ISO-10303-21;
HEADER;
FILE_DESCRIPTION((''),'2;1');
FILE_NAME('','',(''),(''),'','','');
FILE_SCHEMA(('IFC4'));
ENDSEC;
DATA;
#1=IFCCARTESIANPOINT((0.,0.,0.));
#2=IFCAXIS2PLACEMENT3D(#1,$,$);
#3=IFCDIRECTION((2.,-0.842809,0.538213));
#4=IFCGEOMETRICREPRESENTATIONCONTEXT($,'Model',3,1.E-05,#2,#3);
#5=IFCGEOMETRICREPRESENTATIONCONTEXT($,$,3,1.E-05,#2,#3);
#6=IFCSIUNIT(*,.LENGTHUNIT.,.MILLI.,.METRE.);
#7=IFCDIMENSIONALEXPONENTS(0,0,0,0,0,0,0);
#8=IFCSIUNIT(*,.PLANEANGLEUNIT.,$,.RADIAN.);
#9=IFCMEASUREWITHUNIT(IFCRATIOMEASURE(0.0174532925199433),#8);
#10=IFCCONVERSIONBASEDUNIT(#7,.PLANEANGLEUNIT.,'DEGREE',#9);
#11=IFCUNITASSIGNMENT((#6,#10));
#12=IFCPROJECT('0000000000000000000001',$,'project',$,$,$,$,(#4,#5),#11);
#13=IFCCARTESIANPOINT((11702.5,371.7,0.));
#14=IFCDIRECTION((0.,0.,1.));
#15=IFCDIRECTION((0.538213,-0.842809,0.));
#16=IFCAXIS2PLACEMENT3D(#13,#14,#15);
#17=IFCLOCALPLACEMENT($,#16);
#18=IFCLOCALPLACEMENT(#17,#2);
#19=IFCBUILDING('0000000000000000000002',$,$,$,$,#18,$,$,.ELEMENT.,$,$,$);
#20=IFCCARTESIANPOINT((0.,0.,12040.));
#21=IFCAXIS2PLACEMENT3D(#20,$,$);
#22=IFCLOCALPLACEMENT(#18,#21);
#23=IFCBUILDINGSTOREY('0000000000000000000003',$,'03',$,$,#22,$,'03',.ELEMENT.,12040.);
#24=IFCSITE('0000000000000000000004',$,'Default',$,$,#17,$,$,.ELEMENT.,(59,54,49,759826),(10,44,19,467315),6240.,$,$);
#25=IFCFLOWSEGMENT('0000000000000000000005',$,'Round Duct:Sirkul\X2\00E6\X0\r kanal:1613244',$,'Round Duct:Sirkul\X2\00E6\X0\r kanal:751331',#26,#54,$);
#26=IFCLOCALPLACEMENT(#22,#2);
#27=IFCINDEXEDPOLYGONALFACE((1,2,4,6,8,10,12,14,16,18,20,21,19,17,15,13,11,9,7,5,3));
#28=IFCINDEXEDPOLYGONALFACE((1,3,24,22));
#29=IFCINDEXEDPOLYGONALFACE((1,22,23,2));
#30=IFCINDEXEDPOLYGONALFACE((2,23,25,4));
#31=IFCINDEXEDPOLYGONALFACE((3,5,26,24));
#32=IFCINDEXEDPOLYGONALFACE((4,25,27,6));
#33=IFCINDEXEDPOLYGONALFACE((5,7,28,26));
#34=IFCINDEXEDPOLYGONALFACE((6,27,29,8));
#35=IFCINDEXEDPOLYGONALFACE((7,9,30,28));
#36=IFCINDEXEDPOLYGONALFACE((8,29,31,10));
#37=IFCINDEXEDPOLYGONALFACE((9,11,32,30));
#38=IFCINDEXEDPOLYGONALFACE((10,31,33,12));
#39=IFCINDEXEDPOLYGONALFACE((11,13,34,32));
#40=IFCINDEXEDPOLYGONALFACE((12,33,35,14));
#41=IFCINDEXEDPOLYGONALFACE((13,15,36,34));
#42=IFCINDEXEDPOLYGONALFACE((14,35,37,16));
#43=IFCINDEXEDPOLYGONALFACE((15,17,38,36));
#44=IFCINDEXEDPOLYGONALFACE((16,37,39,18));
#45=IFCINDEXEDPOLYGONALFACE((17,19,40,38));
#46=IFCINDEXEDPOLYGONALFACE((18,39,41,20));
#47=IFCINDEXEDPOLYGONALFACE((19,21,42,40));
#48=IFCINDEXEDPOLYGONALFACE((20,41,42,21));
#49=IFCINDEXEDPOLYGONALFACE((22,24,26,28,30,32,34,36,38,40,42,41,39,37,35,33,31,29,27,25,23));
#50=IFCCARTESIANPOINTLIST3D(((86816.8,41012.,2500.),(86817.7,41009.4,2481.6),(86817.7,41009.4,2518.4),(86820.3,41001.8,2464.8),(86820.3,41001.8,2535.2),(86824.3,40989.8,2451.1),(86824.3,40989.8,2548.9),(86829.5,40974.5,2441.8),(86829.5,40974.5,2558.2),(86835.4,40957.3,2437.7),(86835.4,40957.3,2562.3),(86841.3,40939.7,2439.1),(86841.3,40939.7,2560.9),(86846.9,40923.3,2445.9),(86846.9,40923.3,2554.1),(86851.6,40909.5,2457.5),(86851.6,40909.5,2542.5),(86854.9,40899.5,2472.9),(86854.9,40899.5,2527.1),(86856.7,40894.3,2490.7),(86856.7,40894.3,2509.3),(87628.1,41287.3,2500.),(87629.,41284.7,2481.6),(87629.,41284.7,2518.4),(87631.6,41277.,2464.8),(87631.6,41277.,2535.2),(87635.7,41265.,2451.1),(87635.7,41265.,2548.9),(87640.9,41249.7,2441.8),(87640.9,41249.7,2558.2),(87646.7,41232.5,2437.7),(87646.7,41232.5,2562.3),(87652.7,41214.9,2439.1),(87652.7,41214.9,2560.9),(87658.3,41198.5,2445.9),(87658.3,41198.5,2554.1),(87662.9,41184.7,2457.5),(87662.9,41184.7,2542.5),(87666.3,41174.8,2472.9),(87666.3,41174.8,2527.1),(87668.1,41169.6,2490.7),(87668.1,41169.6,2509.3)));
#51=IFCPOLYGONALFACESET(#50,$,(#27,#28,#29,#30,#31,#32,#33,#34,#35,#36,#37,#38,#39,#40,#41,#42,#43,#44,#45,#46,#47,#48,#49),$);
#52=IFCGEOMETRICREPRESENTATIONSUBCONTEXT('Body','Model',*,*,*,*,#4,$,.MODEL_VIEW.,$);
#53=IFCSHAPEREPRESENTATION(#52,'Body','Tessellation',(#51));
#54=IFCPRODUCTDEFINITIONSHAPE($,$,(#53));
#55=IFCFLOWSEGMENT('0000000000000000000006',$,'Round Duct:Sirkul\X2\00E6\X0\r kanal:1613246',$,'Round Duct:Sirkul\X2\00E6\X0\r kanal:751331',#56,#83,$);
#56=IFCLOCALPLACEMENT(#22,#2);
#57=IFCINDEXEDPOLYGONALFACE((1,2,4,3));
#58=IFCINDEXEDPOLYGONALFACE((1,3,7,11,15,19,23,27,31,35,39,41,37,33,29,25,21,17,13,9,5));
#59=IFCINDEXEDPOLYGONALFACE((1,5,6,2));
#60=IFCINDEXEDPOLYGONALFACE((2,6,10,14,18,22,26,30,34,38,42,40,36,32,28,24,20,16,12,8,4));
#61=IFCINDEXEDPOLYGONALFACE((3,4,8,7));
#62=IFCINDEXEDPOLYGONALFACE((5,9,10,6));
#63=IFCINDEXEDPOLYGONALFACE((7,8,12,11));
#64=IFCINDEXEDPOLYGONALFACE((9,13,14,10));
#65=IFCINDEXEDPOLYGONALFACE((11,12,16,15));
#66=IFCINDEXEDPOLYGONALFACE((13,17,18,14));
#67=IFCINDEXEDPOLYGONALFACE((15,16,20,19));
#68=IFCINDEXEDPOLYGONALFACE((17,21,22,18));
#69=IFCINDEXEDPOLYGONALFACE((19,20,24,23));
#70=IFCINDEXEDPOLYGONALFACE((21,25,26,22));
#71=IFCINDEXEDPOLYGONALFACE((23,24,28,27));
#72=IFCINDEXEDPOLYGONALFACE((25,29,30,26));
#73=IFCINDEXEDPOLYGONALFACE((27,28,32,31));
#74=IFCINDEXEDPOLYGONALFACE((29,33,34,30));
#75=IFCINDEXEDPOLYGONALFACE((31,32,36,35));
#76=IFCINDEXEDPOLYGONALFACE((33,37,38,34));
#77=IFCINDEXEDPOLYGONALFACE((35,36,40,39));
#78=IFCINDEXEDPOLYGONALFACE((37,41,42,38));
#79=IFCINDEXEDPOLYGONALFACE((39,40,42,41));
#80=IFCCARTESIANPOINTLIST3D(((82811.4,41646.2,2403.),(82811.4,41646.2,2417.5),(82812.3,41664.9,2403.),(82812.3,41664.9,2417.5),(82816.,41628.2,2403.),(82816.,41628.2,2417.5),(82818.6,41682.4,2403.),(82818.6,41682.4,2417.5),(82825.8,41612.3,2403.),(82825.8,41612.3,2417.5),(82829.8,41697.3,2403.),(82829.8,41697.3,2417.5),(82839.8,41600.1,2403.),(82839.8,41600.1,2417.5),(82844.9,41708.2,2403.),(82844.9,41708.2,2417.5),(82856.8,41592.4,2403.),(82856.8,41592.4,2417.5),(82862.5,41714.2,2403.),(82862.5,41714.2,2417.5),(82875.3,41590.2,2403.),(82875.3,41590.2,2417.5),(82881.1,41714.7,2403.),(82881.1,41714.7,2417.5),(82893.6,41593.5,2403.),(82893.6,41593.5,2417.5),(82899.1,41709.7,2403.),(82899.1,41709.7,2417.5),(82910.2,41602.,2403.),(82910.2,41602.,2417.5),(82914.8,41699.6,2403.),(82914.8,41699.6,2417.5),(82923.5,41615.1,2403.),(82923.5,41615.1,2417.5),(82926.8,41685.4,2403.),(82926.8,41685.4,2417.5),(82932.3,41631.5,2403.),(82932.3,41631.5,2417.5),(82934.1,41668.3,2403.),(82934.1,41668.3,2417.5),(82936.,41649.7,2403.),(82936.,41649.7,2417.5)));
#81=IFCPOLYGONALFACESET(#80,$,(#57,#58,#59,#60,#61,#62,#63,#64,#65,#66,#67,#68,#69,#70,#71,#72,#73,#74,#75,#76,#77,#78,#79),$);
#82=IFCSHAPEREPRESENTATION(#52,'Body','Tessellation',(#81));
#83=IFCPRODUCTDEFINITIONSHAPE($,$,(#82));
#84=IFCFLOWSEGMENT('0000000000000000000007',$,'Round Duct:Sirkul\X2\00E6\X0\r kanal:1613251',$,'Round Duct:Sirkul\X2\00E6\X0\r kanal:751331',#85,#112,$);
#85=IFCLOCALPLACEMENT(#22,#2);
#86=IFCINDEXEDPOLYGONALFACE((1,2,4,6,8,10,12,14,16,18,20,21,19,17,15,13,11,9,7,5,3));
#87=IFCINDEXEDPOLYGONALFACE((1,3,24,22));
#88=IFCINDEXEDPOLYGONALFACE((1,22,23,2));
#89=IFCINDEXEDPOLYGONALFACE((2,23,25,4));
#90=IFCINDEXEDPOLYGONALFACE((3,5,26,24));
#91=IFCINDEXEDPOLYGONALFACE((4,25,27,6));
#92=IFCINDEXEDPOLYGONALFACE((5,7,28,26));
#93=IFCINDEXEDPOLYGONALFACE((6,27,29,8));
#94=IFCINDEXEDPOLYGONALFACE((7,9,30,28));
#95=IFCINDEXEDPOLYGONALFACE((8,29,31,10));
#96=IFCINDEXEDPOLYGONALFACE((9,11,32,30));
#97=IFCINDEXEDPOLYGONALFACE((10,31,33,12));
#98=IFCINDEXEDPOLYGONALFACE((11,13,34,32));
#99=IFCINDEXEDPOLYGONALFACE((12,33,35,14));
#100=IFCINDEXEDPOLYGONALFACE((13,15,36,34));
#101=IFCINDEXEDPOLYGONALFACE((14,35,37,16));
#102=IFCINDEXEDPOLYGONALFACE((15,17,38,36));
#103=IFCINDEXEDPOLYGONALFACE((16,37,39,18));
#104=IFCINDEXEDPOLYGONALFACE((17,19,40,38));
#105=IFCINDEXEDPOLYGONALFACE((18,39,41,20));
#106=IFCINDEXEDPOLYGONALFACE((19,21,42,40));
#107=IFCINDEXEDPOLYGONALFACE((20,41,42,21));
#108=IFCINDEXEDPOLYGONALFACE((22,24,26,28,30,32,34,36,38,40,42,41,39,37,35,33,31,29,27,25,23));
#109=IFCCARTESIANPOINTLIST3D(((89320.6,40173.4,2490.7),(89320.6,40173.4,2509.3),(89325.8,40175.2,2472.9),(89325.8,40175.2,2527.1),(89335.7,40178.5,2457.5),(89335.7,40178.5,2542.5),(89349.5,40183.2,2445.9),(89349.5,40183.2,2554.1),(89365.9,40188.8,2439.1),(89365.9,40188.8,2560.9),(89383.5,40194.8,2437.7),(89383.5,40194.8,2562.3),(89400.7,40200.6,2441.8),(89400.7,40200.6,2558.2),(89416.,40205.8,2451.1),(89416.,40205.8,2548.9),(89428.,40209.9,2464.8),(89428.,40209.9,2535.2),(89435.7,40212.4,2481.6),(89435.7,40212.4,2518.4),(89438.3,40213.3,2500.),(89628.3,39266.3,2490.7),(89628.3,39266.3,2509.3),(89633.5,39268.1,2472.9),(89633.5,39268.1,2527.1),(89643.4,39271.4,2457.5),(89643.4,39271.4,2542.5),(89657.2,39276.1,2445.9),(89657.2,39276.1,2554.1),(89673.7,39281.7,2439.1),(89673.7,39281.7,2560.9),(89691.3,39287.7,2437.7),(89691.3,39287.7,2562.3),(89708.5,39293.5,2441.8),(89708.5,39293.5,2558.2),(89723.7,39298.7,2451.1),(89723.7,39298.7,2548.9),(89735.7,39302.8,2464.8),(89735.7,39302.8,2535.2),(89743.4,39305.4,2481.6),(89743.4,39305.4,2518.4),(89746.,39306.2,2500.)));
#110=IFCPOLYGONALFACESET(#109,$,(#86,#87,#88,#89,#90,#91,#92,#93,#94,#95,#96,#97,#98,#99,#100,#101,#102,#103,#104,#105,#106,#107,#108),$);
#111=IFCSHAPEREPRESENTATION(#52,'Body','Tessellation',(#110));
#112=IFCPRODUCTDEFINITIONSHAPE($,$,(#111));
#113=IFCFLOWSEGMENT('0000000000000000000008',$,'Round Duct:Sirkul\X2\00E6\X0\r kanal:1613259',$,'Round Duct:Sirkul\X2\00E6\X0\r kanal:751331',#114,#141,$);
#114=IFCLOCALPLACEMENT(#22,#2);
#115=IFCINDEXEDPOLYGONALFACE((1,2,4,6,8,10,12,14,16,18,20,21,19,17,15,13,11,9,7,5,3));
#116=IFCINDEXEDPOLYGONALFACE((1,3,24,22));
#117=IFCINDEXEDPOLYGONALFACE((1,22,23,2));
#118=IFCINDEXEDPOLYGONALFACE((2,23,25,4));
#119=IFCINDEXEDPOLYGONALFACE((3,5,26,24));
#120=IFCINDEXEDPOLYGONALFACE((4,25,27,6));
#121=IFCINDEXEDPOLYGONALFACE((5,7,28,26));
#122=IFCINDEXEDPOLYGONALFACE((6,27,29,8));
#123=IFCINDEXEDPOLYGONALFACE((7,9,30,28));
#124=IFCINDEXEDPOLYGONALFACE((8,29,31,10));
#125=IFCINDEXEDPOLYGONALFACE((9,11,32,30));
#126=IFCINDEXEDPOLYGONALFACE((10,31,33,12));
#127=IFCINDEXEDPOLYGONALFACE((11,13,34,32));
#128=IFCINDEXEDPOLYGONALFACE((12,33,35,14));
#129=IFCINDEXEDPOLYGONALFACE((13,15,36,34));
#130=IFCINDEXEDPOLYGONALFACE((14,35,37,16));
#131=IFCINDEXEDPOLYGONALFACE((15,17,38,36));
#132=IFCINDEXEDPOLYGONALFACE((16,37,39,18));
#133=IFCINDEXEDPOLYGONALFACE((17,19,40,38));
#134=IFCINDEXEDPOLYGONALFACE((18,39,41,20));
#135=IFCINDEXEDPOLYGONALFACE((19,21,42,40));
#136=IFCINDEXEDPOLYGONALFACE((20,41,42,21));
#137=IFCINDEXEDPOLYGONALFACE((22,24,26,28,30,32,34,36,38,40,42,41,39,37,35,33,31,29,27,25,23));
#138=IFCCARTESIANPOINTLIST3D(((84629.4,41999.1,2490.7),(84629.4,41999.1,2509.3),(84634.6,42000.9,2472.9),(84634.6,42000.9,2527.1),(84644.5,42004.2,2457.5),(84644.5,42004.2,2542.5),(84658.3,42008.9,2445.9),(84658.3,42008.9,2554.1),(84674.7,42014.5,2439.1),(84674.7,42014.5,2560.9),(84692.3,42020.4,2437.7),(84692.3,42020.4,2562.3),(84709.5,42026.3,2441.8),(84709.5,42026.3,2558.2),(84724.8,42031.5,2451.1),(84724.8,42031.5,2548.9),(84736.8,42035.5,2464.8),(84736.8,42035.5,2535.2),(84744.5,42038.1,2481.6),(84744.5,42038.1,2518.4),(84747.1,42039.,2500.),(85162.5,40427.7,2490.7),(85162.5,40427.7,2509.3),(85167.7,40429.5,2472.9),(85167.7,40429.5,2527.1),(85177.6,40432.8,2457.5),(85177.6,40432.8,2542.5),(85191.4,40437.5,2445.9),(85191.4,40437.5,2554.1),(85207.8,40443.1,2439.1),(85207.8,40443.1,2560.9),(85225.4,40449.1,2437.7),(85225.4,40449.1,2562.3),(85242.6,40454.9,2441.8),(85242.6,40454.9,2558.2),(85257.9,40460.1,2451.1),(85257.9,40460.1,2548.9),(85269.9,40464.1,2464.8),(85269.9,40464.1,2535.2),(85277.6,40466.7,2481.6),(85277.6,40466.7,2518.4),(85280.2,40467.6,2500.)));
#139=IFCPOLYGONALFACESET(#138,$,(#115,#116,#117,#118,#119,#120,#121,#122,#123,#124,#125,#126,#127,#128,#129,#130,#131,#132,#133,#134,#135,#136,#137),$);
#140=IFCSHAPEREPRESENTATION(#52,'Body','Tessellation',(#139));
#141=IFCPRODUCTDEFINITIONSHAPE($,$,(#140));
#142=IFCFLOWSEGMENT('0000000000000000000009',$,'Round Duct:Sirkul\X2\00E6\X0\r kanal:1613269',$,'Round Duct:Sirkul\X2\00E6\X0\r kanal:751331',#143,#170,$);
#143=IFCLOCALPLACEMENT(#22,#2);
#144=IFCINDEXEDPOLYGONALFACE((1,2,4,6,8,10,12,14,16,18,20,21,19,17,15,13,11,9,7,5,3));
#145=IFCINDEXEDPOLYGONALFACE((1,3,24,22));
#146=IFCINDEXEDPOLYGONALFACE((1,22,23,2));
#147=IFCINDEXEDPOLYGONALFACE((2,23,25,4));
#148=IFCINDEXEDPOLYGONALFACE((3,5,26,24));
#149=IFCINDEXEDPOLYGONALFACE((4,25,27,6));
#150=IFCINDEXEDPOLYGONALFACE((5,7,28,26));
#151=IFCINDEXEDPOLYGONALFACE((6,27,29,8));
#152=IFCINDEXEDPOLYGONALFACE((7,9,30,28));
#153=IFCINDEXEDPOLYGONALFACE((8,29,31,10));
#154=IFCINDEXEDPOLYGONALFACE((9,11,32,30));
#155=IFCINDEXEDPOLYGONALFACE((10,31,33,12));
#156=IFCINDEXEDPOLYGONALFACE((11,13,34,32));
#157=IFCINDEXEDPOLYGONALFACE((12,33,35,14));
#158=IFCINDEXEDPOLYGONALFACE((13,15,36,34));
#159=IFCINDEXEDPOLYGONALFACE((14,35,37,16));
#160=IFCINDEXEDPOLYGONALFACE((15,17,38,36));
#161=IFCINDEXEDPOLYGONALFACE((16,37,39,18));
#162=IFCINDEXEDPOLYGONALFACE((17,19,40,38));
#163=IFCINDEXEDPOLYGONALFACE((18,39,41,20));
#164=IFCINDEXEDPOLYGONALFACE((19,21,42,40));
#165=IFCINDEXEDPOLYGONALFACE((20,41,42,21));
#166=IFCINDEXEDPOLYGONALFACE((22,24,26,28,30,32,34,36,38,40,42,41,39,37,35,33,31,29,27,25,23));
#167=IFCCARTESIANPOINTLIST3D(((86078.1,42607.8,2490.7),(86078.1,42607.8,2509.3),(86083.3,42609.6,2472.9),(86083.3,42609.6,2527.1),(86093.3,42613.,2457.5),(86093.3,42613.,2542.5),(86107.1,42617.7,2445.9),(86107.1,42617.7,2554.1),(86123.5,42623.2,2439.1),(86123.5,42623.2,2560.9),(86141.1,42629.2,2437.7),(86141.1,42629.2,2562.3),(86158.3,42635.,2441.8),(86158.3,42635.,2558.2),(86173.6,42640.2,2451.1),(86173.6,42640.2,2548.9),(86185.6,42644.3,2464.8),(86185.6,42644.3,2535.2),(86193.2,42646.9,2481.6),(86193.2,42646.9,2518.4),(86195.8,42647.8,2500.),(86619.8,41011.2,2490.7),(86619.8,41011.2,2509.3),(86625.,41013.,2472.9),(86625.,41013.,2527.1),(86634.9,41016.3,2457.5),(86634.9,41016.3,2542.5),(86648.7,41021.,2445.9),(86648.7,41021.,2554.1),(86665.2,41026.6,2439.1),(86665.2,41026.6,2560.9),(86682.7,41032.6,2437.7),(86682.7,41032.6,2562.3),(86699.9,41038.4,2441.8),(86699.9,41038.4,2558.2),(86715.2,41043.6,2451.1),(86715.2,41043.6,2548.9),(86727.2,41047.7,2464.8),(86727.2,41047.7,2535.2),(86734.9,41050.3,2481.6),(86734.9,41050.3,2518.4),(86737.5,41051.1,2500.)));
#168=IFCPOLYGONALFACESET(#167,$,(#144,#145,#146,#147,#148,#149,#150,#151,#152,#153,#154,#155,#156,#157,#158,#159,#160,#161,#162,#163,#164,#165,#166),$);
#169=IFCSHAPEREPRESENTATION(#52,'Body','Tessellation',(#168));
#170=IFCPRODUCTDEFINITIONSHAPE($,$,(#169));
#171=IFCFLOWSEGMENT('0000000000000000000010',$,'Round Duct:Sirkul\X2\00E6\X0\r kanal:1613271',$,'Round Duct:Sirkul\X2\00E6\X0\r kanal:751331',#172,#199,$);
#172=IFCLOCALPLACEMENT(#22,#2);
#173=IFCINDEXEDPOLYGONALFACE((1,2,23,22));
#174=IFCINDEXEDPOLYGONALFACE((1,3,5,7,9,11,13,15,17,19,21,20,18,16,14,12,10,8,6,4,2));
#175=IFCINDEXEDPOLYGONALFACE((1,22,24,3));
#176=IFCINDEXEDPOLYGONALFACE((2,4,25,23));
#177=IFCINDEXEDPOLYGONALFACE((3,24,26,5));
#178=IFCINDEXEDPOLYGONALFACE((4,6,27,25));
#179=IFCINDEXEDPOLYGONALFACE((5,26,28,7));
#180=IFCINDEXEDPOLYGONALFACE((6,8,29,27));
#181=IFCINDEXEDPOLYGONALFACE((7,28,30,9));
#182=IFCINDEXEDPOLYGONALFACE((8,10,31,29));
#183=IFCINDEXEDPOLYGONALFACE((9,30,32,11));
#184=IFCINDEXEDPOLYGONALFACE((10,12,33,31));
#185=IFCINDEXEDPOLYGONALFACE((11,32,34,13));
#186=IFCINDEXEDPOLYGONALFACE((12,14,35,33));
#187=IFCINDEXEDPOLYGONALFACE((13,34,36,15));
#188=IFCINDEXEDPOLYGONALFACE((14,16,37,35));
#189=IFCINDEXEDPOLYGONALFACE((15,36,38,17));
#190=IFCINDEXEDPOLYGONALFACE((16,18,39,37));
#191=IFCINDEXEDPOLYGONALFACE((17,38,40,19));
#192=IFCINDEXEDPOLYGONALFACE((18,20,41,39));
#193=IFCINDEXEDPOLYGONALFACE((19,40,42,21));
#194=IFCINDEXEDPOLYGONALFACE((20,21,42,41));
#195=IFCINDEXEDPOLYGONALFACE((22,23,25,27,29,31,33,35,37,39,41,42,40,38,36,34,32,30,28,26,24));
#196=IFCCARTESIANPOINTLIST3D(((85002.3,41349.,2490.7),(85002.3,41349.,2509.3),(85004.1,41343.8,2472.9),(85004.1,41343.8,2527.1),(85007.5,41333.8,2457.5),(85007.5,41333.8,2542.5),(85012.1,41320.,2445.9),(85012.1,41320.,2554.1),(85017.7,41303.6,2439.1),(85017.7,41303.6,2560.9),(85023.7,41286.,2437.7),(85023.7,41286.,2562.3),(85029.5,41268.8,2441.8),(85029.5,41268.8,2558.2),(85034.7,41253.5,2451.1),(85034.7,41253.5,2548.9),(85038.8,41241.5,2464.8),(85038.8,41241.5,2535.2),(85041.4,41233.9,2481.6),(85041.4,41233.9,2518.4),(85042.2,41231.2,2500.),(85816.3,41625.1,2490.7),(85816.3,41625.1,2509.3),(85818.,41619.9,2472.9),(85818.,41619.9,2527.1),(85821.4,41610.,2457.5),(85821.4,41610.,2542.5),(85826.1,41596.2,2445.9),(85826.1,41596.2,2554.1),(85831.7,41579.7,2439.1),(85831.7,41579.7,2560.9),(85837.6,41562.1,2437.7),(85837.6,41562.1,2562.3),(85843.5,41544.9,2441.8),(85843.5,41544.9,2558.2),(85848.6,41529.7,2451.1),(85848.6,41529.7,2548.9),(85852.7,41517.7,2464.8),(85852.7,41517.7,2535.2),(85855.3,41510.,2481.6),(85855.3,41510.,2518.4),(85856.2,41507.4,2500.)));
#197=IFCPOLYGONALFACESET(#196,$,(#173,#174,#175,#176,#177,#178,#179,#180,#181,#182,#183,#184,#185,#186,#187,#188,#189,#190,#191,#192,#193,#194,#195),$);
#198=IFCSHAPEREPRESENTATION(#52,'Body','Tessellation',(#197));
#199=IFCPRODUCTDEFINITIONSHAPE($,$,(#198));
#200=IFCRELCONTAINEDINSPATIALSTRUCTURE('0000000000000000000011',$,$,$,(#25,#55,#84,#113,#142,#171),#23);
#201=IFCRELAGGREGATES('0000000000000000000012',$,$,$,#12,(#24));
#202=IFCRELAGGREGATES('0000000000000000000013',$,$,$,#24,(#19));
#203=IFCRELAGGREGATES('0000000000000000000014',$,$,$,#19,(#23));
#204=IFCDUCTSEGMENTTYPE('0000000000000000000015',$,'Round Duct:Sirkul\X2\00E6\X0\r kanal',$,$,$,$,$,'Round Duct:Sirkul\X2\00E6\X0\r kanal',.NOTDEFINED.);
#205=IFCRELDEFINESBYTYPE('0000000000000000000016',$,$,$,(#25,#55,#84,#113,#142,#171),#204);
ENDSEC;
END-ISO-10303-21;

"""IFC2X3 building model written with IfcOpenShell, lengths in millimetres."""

from ifc_helpers import new_model, entity, si_unit, converted_unit, direction, frame, frame_2d, origin, origin_2d_with_axis, place, context, subcontext, project, spatial, circle, extrude, type_object, element, save


model = new_model("IFC2X3")

# Units and contexts
model_context = context("Model", 3, precision=1e-05, world=origin(), true_north=direction((2.0, -0.842809, 0.538213)))
context_of_model = context(None, 3, precision=1e-05, world=origin(), true_north=direction((2.0, -0.842809, 0.538213)))
body_context = subcontext(model_context, "Body", "Model", "MODEL_VIEW")
ifc_project = project(units=[si_unit("LENGTHUNIT", "METRE", prefix="MILLI"), converted_unit("PLANEANGLEUNIT", "DEGREE", entity("IfcRatioMeasure", 0.0174532925199433), si_unit("PLANEANGLEUNIT", "RADIAN"), dimensions=[0, 0, 0, 0, 0, 0, 0])], contexts=[model_context, context_of_model])

# Site, building, storey
site_placement = place(None, frame((11702.5, 371.7, 0.0), z_axis=(0.0, 0.0, 1.0), x_axis=(0.538213, -0.842809, 0.0)))
site = spatial("IfcSite", under=ifc_project, at=site_placement, Name="Default", CompositionType="ELEMENT", RefLatitude=(59, 54, 49, 759826), RefLongitude=(10, 44, 19, 467315), RefElevation=6240.0)
building_placement = place(site_placement, origin())
building = spatial("IfcBuilding", under=site, at=building_placement, CompositionType="ELEMENT")
storey_placement = place(building_placement, frame((0.0, 0.0, 12040.0)))
storey = spatial("IfcBuildingStorey", under=building, at=storey_placement, Name="03", LongName="03", CompositionType="ELEMENT", Elevation=12040.0)

# Flow segments
duct_segment_type = type_object("IfcDuctSegmentType", Name="Round Duct:Sirkulær kanal", ElementType="Round Duct:Sirkulær kanal", PredefinedType="NOTDEFINED")
flow_segment_1_placement = place(storey_placement, origin())
element("IfcFlowSegment", 1, at=flow_segment_1_placement, inside=storey, type_object=duct_segment_type, Name="Round Duct:Sirkulær kanal:1613244", ObjectType="Round Duct:Sirkulær kanal:751331", context=body_context, shape_type="SweptSolid", body=[
    extrude(circle(Radius=62.5, at=frame_2d((0.0, 0.0), x_axis=(1.0, 0.0))), frame((86836.9, 40952.9, 2500.0), z_axis=(0.946986, 0.321274, 0.0), x_axis=(-0.321274, 0.946986, 0.0)), (0.0, 0.0, 1.0), 856.8),
])
flow_segment_2_placement = place(storey_placement, origin())
element("IfcFlowSegment", 2, at=flow_segment_2_placement, inside=storey, type_object=duct_segment_type, Name="Round Duct:Sirkulær kanal:1613246", ObjectType="Round Duct:Sirkulær kanal:751331", context=body_context, shape_type="SweptSolid", body=[
    extrude(circle(Radius=62.5, at=origin_2d_with_axis()), frame((82873.6, 41652.7, 2403.0), z_axis=(0.0, 0.0, 1.0), x_axis=(0.321274, -0.946986, 0.0)), (0.0, 0.0, 1.0), 14.5),
])
flow_segment_3_placement = place(storey_placement, origin())
element("IfcFlowSegment", 3, at=flow_segment_3_placement, inside=storey, type_object=duct_segment_type, Name="Round Duct:Sirkulær kanal:1613251", ObjectType="Round Duct:Sirkulær kanal:751331", context=body_context, shape_type="SweptSolid", body=[
    extrude(circle(Radius=62.5, at=origin_2d_with_axis()), frame((89686.8, 39286.2, 2500.0), z_axis=(-0.321274, 0.946986, 0.0), x_axis=(0.946986, 0.321274, 0.0)), (0.0, 0.0, 1.0), 957.9),
])
flow_segment_4_placement = place(storey_placement, origin())
element("IfcFlowSegment", 4, at=flow_segment_4_placement, inside=storey, type_object=duct_segment_type, Name="Round Duct:Sirkulær kanal:1613259", ObjectType="Round Duct:Sirkulær kanal:751331", context=body_context, shape_type="SweptSolid", body=[
    extrude(circle(Radius=62.5, at=frame_2d((0.0, 0.0), x_axis=(1.0, 0.0))), frame((84687.9, 42018.9, 2500.0), z_axis=(0.321274, -0.946986, 0.0), x_axis=(0.946986, 0.321274, 0.0)), (0.0, 0.0, 1.0), 1659.4),
])
flow_segment_5_placement = place(storey_placement, origin())
element("IfcFlowSegment", 5, at=flow_segment_5_placement, inside=storey, type_object=duct_segment_type, Name="Round Duct:Sirkulær kanal:1613269", ObjectType="Round Duct:Sirkulær kanal:751331", context=body_context, shape_type="SweptSolid", body=[
    extrude(circle(Radius=62.5, at=origin_2d_with_axis()), frame((86136.7, 42627.7, 2500.0), z_axis=(0.321276, -0.946985, 0.0), x_axis=(0.946985, 0.321276, 0.0)), (0.0, 0.0, 1.0), 1686.0),
])
flow_segment_6_placement = place(storey_placement, origin())
element("IfcFlowSegment", 6, at=flow_segment_6_placement, inside=storey, type_object=duct_segment_type, Name="Round Duct:Sirkulær kanal:1613271", ObjectType="Round Duct:Sirkulær kanal:751331", context=body_context, shape_type="SweptSolid", body=[
    extrude(circle(Radius=62.5, at=origin_2d_with_axis()), frame((85022.2, 41290.4, 2500.0), z_axis=(0.946986, 0.321274, 0.0), x_axis=(0.321274, -0.946986, 0.0)), (0.0, 0.0, 1.0), 859.5),
])

save(model, "model.ifc")
